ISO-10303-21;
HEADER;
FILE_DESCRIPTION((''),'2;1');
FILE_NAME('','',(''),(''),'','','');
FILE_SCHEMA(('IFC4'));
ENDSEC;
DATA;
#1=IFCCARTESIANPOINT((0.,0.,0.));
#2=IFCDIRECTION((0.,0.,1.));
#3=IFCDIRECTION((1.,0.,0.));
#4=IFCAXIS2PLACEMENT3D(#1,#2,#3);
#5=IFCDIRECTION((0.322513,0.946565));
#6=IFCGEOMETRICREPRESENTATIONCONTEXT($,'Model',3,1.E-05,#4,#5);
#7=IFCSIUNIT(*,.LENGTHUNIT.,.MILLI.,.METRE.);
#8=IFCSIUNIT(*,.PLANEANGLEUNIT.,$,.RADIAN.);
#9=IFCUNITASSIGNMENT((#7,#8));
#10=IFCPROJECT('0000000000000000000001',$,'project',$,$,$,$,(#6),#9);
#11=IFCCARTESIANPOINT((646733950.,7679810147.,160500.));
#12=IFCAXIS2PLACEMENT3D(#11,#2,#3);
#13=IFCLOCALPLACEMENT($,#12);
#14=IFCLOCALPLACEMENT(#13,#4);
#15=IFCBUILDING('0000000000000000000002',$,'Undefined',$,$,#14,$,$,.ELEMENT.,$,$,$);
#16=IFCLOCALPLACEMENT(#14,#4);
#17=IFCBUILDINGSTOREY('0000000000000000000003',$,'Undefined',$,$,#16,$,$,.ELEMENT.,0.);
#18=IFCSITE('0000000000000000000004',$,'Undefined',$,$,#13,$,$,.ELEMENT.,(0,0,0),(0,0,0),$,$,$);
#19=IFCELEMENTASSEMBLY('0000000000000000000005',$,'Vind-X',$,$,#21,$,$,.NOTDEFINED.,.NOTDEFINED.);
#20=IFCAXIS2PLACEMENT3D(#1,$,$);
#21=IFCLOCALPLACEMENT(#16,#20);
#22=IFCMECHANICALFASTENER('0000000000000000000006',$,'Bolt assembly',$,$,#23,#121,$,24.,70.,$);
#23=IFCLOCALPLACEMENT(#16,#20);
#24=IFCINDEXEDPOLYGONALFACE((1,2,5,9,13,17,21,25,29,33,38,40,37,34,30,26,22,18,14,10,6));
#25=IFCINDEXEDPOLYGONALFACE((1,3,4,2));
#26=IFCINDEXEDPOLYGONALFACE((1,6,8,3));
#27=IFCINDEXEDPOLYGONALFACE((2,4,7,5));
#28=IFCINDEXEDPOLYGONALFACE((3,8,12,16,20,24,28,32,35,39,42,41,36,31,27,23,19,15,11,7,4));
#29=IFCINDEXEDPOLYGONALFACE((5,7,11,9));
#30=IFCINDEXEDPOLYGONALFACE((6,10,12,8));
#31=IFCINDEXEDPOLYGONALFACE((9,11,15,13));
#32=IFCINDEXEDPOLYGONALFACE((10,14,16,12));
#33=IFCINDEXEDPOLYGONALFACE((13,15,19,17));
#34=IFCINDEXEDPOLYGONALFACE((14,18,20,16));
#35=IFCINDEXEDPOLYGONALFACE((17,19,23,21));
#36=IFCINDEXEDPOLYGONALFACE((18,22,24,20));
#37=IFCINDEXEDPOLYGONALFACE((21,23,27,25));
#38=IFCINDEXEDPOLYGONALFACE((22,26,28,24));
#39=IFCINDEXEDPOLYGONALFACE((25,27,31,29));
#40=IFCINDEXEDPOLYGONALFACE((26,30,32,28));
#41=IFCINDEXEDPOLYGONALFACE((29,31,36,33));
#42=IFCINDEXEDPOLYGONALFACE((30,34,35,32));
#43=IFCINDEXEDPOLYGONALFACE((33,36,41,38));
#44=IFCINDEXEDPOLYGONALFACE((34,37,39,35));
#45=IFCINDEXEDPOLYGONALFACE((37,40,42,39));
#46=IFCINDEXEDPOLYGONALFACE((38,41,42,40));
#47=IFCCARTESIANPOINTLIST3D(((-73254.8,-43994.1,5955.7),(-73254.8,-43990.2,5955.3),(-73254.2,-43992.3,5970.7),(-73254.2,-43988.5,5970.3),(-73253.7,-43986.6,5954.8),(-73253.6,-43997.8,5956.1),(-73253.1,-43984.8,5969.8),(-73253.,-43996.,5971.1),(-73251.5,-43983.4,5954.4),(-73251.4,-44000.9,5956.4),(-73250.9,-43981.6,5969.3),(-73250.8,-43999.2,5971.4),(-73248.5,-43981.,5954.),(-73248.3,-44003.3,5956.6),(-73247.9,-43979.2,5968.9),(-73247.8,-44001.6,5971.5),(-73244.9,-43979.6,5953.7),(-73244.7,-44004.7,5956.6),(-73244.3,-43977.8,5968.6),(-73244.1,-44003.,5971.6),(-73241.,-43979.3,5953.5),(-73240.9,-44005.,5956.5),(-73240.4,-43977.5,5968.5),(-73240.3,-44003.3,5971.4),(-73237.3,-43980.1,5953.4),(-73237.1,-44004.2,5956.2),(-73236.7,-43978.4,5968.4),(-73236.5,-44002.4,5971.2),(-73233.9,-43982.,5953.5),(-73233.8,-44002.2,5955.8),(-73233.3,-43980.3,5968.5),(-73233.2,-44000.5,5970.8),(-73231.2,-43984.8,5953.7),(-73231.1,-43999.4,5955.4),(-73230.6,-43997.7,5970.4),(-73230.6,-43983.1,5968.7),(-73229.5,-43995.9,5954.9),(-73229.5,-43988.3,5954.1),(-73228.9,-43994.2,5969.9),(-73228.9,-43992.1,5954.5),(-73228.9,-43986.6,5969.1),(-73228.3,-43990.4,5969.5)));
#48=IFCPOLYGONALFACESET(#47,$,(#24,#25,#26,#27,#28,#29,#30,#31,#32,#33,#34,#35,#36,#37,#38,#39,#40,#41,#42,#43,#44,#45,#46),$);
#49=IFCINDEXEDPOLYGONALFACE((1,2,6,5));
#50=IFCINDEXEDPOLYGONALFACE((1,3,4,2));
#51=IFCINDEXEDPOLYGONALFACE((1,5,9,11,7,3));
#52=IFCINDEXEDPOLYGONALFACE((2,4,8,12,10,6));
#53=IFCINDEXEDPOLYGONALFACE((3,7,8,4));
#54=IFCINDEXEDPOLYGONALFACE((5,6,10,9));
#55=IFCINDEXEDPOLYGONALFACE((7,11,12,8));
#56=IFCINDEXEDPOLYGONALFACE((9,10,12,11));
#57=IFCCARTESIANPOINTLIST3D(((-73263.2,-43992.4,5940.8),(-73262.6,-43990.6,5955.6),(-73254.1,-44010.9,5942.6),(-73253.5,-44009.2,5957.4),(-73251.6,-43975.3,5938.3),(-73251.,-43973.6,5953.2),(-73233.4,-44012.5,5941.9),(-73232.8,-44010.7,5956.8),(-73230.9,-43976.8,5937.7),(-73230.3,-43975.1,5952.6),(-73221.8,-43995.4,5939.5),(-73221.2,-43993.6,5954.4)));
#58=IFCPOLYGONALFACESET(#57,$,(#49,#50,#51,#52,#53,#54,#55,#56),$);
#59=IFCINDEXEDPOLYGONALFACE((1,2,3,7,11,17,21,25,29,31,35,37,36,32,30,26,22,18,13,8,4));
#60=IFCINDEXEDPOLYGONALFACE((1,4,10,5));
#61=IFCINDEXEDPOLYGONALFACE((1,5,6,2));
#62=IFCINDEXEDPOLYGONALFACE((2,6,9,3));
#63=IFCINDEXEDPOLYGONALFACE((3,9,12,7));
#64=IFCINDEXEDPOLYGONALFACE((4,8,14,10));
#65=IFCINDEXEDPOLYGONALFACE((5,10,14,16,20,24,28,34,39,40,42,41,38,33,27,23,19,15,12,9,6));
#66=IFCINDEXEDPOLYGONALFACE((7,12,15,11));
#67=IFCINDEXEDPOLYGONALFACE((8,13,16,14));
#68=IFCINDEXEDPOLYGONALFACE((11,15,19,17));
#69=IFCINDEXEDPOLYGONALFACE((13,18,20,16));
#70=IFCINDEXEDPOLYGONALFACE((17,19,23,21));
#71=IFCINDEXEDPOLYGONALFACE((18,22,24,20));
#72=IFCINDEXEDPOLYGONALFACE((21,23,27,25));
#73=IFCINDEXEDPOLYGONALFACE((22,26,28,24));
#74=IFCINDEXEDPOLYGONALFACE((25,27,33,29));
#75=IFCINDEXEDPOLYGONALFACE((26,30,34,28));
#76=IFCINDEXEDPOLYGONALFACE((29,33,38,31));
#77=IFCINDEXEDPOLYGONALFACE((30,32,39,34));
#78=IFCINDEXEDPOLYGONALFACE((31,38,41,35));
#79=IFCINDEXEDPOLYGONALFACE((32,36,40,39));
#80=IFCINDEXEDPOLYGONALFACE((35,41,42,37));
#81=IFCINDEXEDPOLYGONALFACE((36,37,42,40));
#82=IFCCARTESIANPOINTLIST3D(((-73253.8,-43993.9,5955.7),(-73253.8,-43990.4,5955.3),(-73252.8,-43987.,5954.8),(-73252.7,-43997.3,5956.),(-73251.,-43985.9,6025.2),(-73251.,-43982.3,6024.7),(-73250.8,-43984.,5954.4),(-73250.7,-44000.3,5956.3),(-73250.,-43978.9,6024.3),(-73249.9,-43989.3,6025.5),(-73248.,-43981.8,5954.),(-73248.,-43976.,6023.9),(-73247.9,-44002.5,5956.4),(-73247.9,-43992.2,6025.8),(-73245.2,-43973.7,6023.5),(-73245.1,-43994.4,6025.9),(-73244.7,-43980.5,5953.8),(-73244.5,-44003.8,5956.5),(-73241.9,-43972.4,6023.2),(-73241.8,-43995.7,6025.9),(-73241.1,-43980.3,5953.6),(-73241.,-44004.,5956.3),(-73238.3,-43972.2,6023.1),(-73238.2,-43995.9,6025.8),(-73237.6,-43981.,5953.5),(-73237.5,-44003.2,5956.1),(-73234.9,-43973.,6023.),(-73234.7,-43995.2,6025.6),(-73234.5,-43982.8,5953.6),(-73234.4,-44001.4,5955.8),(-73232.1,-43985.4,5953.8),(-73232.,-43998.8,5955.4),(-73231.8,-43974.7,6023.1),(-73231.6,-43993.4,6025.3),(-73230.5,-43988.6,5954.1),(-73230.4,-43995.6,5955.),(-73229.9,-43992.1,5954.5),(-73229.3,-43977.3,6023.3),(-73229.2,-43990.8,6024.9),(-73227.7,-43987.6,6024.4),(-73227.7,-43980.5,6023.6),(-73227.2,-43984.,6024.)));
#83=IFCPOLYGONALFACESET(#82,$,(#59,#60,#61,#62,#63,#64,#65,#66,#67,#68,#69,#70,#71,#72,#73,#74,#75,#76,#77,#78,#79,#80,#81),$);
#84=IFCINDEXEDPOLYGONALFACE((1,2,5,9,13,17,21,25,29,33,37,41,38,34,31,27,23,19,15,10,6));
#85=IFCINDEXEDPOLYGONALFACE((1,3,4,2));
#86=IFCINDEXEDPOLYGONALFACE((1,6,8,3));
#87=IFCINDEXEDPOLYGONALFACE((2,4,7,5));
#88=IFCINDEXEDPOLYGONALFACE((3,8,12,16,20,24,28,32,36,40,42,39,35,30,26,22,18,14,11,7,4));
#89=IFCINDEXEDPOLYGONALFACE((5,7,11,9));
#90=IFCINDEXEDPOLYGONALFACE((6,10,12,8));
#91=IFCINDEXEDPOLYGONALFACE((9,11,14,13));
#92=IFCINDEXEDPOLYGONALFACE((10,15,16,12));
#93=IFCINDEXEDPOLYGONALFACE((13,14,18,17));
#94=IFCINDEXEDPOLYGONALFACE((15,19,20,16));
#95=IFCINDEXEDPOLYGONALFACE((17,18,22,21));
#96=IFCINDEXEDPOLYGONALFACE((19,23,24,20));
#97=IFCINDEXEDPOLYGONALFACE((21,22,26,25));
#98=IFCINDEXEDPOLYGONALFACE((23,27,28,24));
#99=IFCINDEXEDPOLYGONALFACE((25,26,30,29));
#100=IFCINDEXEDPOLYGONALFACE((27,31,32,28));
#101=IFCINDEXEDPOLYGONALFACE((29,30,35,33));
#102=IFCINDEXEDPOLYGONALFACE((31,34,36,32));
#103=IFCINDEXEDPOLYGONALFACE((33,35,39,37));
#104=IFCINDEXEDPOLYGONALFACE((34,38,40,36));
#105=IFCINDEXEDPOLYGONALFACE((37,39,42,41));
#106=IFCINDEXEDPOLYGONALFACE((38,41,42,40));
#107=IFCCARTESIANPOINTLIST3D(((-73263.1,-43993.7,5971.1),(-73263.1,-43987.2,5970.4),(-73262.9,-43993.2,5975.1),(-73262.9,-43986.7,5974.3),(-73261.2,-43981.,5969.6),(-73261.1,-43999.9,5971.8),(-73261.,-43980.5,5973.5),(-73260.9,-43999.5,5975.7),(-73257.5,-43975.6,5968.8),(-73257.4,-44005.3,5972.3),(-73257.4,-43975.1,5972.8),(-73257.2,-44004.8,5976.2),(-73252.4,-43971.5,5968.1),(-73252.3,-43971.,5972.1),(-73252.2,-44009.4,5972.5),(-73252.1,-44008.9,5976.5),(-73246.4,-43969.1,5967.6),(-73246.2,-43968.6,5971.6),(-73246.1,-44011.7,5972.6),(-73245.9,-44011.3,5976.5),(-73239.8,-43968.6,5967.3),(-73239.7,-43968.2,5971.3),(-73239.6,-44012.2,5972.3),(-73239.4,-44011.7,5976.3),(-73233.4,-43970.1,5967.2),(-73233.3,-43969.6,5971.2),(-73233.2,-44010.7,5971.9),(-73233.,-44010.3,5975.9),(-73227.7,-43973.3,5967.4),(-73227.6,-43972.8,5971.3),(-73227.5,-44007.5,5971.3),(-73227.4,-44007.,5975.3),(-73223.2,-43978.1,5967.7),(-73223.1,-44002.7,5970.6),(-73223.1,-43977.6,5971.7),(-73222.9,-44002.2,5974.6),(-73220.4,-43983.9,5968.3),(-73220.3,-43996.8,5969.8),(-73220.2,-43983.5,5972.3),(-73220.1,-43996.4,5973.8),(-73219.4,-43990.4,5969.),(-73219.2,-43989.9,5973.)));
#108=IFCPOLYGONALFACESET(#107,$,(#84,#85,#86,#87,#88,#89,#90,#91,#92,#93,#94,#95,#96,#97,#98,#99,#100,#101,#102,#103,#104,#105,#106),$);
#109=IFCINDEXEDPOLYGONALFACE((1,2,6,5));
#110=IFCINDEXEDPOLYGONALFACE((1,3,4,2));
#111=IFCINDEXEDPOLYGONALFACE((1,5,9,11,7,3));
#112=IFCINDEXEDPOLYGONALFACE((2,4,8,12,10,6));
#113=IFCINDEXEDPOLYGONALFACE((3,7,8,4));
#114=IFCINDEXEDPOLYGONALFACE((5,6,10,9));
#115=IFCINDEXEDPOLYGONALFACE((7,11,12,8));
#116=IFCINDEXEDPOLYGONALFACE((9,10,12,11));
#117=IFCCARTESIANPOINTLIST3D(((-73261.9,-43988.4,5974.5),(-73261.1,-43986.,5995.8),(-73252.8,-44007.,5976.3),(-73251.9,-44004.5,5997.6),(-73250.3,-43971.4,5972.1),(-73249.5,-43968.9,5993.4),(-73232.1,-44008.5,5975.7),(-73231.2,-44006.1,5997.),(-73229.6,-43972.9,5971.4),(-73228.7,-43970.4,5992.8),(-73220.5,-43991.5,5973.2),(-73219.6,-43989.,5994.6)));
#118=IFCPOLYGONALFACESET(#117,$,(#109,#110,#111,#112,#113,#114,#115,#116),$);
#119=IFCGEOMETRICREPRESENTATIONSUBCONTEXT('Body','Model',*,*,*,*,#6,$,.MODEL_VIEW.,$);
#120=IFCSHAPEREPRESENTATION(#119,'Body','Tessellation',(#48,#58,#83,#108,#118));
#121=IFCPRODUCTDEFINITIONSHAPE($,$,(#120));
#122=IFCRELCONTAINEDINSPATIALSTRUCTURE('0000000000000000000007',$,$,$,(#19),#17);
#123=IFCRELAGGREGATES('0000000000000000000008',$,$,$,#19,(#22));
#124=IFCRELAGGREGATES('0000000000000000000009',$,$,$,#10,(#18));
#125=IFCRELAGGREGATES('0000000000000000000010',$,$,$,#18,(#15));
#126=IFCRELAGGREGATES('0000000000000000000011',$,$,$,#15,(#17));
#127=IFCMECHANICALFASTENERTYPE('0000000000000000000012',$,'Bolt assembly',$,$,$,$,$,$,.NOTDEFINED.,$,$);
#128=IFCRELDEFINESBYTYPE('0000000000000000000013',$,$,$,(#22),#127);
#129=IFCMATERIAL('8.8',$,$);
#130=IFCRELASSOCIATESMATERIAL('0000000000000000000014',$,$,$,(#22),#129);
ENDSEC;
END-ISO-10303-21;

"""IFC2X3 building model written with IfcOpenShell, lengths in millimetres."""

from ifc_helpers import new_model, si_unit, direction, frame, origin_with_axes, origin_2d_with_axis, place, context, subcontext, project, spatial, polyline, circle, outline, extrude, source, transform, mapped, material, type_object, element, aggregate, save


model = new_model("IFC2X3")

# Units and contexts
model_context = context("Model", 3, precision=1e-05, world=origin_with_axes(), true_north=direction((0.322513, 0.946565)))
body_context = subcontext(model_context, "Body", "Model", "MODEL_VIEW")
ifc_project = project(units=[si_unit("LENGTHUNIT", "METRE", prefix="MILLI"), si_unit("PLANEANGLEUNIT", "RADIAN")], contexts=[model_context])

# Site, building, storey
site_placement = place(None, frame((646733950.0, 7679810147.0, 160500.0), z_axis=(0.0, 0.0, 1.0), x_axis=(1.0, 0.0, 0.0)))
site = spatial("IfcSite", under=ifc_project, at=site_placement, Name="Undefined", CompositionType="ELEMENT", RefLatitude=(0, 0, 0), RefLongitude=(0, 0, 0))
building_placement = place(site_placement, origin_with_axes())
building = spatial("IfcBuilding", under=site, at=building_placement, Name="Undefined", CompositionType="ELEMENT")
storey_placement = place(building_placement, origin_with_axes())
storey = spatial("IfcBuildingStorey", under=building, at=storey_placement, Name="Undefined", CompositionType="ELEMENT", Elevation=0.0)

# Element assembly
assembly_1_placement = place(storey_placement, origin_with_axes())
assembly_1 = element("IfcElementAssembly", 1, at=assembly_1_placement, inside=storey, Name="Vind-X", AssemblyPlace="NOTDEFINED", PredefinedType="NOTDEFINED")

# Mechanical fastener
ifc_material_1 = material(Name="8.8")
mechanical_fastener_type = type_object("IfcMechanicalFastenerType", Name="Bolt assembly")
shared_shape_1 = source(origin_with_axes(), body_context, "Body", "SweptSolid", [
    extrude(circle(Radius=13.0, at=origin_2d_with_axis()), frame((0.0, 0.0, 0.0), z_axis=(0.0, 1.0, 0.0), x_axis=(1.0, 0.0, 0.0)), (0.0, 0.0, 1.0), 15.1),
    extrude(outline(polyline([(18.0, -10.4), (18.0, 10.4), (0.0, 20.8), (-18.0, 10.4), (-18.0, -10.4), (0.0, -20.8), (18.0, -10.4)])), frame((0.0, -15.0, 0.0), z_axis=(0.0, 1.0, 0.0), x_axis=(1.0, 0.0, 0.0)), (0.0, 0.0, 1.0), 15.0),
    extrude(circle(Radius=12.0, at=origin_2d_with_axis()), frame((0.0, 0.0, 0.0), z_axis=(0.0, 1.0, 0.0), x_axis=(1.0, 0.0, 0.0)), (0.0, 0.0, 1.0), 70.0),
    extrude(circle(Radius=22.0, at=origin_2d_with_axis()), frame((0.0, 15.0, 0.0), z_axis=(0.0, 1.0, 0.0), x_axis=(1.0, 0.0, 0.0)), (0.0, 0.0, 1.0), 4.0),
    extrude(outline(polyline([(18.0, -10.4), (18.0, 10.4), (0.0, 20.8), (-18.0, 10.4), (-18.0, -10.4), (0.0, -20.8), (18.0, -10.4)])), frame((0.0, 19.0, 0.0), z_axis=(0.0, 1.0, 0.0), x_axis=(1.0, 0.0, 0.0)), (0.0, 0.0, 1.0), 21.5),
])
mechanical_fastener_1_placement = place(assembly_1_placement, frame((-73241.9, -43992.1, 5955.0), z_axis=(-0.439079, 0.89427, -0.086548), x_axis=(-0.897588, -0.432405, 0.0858)))
mechanical_fastener_1 = element("IfcMechanicalFastener", 2, at=mechanical_fastener_1_placement, type_object=mechanical_fastener_type, material=ifc_material_1, Name="Bolt assembly", NominalDiameter=24.0, NominalLength=70.0, context=body_context, shape_type="MappedRepresentation", body=[
    mapped(shared_shape_1, transform((0.0, 0.0, 0.0))),
])
aggregate(assembly_1, [mechanical_fastener_1])

save(model, "model.ifc")
